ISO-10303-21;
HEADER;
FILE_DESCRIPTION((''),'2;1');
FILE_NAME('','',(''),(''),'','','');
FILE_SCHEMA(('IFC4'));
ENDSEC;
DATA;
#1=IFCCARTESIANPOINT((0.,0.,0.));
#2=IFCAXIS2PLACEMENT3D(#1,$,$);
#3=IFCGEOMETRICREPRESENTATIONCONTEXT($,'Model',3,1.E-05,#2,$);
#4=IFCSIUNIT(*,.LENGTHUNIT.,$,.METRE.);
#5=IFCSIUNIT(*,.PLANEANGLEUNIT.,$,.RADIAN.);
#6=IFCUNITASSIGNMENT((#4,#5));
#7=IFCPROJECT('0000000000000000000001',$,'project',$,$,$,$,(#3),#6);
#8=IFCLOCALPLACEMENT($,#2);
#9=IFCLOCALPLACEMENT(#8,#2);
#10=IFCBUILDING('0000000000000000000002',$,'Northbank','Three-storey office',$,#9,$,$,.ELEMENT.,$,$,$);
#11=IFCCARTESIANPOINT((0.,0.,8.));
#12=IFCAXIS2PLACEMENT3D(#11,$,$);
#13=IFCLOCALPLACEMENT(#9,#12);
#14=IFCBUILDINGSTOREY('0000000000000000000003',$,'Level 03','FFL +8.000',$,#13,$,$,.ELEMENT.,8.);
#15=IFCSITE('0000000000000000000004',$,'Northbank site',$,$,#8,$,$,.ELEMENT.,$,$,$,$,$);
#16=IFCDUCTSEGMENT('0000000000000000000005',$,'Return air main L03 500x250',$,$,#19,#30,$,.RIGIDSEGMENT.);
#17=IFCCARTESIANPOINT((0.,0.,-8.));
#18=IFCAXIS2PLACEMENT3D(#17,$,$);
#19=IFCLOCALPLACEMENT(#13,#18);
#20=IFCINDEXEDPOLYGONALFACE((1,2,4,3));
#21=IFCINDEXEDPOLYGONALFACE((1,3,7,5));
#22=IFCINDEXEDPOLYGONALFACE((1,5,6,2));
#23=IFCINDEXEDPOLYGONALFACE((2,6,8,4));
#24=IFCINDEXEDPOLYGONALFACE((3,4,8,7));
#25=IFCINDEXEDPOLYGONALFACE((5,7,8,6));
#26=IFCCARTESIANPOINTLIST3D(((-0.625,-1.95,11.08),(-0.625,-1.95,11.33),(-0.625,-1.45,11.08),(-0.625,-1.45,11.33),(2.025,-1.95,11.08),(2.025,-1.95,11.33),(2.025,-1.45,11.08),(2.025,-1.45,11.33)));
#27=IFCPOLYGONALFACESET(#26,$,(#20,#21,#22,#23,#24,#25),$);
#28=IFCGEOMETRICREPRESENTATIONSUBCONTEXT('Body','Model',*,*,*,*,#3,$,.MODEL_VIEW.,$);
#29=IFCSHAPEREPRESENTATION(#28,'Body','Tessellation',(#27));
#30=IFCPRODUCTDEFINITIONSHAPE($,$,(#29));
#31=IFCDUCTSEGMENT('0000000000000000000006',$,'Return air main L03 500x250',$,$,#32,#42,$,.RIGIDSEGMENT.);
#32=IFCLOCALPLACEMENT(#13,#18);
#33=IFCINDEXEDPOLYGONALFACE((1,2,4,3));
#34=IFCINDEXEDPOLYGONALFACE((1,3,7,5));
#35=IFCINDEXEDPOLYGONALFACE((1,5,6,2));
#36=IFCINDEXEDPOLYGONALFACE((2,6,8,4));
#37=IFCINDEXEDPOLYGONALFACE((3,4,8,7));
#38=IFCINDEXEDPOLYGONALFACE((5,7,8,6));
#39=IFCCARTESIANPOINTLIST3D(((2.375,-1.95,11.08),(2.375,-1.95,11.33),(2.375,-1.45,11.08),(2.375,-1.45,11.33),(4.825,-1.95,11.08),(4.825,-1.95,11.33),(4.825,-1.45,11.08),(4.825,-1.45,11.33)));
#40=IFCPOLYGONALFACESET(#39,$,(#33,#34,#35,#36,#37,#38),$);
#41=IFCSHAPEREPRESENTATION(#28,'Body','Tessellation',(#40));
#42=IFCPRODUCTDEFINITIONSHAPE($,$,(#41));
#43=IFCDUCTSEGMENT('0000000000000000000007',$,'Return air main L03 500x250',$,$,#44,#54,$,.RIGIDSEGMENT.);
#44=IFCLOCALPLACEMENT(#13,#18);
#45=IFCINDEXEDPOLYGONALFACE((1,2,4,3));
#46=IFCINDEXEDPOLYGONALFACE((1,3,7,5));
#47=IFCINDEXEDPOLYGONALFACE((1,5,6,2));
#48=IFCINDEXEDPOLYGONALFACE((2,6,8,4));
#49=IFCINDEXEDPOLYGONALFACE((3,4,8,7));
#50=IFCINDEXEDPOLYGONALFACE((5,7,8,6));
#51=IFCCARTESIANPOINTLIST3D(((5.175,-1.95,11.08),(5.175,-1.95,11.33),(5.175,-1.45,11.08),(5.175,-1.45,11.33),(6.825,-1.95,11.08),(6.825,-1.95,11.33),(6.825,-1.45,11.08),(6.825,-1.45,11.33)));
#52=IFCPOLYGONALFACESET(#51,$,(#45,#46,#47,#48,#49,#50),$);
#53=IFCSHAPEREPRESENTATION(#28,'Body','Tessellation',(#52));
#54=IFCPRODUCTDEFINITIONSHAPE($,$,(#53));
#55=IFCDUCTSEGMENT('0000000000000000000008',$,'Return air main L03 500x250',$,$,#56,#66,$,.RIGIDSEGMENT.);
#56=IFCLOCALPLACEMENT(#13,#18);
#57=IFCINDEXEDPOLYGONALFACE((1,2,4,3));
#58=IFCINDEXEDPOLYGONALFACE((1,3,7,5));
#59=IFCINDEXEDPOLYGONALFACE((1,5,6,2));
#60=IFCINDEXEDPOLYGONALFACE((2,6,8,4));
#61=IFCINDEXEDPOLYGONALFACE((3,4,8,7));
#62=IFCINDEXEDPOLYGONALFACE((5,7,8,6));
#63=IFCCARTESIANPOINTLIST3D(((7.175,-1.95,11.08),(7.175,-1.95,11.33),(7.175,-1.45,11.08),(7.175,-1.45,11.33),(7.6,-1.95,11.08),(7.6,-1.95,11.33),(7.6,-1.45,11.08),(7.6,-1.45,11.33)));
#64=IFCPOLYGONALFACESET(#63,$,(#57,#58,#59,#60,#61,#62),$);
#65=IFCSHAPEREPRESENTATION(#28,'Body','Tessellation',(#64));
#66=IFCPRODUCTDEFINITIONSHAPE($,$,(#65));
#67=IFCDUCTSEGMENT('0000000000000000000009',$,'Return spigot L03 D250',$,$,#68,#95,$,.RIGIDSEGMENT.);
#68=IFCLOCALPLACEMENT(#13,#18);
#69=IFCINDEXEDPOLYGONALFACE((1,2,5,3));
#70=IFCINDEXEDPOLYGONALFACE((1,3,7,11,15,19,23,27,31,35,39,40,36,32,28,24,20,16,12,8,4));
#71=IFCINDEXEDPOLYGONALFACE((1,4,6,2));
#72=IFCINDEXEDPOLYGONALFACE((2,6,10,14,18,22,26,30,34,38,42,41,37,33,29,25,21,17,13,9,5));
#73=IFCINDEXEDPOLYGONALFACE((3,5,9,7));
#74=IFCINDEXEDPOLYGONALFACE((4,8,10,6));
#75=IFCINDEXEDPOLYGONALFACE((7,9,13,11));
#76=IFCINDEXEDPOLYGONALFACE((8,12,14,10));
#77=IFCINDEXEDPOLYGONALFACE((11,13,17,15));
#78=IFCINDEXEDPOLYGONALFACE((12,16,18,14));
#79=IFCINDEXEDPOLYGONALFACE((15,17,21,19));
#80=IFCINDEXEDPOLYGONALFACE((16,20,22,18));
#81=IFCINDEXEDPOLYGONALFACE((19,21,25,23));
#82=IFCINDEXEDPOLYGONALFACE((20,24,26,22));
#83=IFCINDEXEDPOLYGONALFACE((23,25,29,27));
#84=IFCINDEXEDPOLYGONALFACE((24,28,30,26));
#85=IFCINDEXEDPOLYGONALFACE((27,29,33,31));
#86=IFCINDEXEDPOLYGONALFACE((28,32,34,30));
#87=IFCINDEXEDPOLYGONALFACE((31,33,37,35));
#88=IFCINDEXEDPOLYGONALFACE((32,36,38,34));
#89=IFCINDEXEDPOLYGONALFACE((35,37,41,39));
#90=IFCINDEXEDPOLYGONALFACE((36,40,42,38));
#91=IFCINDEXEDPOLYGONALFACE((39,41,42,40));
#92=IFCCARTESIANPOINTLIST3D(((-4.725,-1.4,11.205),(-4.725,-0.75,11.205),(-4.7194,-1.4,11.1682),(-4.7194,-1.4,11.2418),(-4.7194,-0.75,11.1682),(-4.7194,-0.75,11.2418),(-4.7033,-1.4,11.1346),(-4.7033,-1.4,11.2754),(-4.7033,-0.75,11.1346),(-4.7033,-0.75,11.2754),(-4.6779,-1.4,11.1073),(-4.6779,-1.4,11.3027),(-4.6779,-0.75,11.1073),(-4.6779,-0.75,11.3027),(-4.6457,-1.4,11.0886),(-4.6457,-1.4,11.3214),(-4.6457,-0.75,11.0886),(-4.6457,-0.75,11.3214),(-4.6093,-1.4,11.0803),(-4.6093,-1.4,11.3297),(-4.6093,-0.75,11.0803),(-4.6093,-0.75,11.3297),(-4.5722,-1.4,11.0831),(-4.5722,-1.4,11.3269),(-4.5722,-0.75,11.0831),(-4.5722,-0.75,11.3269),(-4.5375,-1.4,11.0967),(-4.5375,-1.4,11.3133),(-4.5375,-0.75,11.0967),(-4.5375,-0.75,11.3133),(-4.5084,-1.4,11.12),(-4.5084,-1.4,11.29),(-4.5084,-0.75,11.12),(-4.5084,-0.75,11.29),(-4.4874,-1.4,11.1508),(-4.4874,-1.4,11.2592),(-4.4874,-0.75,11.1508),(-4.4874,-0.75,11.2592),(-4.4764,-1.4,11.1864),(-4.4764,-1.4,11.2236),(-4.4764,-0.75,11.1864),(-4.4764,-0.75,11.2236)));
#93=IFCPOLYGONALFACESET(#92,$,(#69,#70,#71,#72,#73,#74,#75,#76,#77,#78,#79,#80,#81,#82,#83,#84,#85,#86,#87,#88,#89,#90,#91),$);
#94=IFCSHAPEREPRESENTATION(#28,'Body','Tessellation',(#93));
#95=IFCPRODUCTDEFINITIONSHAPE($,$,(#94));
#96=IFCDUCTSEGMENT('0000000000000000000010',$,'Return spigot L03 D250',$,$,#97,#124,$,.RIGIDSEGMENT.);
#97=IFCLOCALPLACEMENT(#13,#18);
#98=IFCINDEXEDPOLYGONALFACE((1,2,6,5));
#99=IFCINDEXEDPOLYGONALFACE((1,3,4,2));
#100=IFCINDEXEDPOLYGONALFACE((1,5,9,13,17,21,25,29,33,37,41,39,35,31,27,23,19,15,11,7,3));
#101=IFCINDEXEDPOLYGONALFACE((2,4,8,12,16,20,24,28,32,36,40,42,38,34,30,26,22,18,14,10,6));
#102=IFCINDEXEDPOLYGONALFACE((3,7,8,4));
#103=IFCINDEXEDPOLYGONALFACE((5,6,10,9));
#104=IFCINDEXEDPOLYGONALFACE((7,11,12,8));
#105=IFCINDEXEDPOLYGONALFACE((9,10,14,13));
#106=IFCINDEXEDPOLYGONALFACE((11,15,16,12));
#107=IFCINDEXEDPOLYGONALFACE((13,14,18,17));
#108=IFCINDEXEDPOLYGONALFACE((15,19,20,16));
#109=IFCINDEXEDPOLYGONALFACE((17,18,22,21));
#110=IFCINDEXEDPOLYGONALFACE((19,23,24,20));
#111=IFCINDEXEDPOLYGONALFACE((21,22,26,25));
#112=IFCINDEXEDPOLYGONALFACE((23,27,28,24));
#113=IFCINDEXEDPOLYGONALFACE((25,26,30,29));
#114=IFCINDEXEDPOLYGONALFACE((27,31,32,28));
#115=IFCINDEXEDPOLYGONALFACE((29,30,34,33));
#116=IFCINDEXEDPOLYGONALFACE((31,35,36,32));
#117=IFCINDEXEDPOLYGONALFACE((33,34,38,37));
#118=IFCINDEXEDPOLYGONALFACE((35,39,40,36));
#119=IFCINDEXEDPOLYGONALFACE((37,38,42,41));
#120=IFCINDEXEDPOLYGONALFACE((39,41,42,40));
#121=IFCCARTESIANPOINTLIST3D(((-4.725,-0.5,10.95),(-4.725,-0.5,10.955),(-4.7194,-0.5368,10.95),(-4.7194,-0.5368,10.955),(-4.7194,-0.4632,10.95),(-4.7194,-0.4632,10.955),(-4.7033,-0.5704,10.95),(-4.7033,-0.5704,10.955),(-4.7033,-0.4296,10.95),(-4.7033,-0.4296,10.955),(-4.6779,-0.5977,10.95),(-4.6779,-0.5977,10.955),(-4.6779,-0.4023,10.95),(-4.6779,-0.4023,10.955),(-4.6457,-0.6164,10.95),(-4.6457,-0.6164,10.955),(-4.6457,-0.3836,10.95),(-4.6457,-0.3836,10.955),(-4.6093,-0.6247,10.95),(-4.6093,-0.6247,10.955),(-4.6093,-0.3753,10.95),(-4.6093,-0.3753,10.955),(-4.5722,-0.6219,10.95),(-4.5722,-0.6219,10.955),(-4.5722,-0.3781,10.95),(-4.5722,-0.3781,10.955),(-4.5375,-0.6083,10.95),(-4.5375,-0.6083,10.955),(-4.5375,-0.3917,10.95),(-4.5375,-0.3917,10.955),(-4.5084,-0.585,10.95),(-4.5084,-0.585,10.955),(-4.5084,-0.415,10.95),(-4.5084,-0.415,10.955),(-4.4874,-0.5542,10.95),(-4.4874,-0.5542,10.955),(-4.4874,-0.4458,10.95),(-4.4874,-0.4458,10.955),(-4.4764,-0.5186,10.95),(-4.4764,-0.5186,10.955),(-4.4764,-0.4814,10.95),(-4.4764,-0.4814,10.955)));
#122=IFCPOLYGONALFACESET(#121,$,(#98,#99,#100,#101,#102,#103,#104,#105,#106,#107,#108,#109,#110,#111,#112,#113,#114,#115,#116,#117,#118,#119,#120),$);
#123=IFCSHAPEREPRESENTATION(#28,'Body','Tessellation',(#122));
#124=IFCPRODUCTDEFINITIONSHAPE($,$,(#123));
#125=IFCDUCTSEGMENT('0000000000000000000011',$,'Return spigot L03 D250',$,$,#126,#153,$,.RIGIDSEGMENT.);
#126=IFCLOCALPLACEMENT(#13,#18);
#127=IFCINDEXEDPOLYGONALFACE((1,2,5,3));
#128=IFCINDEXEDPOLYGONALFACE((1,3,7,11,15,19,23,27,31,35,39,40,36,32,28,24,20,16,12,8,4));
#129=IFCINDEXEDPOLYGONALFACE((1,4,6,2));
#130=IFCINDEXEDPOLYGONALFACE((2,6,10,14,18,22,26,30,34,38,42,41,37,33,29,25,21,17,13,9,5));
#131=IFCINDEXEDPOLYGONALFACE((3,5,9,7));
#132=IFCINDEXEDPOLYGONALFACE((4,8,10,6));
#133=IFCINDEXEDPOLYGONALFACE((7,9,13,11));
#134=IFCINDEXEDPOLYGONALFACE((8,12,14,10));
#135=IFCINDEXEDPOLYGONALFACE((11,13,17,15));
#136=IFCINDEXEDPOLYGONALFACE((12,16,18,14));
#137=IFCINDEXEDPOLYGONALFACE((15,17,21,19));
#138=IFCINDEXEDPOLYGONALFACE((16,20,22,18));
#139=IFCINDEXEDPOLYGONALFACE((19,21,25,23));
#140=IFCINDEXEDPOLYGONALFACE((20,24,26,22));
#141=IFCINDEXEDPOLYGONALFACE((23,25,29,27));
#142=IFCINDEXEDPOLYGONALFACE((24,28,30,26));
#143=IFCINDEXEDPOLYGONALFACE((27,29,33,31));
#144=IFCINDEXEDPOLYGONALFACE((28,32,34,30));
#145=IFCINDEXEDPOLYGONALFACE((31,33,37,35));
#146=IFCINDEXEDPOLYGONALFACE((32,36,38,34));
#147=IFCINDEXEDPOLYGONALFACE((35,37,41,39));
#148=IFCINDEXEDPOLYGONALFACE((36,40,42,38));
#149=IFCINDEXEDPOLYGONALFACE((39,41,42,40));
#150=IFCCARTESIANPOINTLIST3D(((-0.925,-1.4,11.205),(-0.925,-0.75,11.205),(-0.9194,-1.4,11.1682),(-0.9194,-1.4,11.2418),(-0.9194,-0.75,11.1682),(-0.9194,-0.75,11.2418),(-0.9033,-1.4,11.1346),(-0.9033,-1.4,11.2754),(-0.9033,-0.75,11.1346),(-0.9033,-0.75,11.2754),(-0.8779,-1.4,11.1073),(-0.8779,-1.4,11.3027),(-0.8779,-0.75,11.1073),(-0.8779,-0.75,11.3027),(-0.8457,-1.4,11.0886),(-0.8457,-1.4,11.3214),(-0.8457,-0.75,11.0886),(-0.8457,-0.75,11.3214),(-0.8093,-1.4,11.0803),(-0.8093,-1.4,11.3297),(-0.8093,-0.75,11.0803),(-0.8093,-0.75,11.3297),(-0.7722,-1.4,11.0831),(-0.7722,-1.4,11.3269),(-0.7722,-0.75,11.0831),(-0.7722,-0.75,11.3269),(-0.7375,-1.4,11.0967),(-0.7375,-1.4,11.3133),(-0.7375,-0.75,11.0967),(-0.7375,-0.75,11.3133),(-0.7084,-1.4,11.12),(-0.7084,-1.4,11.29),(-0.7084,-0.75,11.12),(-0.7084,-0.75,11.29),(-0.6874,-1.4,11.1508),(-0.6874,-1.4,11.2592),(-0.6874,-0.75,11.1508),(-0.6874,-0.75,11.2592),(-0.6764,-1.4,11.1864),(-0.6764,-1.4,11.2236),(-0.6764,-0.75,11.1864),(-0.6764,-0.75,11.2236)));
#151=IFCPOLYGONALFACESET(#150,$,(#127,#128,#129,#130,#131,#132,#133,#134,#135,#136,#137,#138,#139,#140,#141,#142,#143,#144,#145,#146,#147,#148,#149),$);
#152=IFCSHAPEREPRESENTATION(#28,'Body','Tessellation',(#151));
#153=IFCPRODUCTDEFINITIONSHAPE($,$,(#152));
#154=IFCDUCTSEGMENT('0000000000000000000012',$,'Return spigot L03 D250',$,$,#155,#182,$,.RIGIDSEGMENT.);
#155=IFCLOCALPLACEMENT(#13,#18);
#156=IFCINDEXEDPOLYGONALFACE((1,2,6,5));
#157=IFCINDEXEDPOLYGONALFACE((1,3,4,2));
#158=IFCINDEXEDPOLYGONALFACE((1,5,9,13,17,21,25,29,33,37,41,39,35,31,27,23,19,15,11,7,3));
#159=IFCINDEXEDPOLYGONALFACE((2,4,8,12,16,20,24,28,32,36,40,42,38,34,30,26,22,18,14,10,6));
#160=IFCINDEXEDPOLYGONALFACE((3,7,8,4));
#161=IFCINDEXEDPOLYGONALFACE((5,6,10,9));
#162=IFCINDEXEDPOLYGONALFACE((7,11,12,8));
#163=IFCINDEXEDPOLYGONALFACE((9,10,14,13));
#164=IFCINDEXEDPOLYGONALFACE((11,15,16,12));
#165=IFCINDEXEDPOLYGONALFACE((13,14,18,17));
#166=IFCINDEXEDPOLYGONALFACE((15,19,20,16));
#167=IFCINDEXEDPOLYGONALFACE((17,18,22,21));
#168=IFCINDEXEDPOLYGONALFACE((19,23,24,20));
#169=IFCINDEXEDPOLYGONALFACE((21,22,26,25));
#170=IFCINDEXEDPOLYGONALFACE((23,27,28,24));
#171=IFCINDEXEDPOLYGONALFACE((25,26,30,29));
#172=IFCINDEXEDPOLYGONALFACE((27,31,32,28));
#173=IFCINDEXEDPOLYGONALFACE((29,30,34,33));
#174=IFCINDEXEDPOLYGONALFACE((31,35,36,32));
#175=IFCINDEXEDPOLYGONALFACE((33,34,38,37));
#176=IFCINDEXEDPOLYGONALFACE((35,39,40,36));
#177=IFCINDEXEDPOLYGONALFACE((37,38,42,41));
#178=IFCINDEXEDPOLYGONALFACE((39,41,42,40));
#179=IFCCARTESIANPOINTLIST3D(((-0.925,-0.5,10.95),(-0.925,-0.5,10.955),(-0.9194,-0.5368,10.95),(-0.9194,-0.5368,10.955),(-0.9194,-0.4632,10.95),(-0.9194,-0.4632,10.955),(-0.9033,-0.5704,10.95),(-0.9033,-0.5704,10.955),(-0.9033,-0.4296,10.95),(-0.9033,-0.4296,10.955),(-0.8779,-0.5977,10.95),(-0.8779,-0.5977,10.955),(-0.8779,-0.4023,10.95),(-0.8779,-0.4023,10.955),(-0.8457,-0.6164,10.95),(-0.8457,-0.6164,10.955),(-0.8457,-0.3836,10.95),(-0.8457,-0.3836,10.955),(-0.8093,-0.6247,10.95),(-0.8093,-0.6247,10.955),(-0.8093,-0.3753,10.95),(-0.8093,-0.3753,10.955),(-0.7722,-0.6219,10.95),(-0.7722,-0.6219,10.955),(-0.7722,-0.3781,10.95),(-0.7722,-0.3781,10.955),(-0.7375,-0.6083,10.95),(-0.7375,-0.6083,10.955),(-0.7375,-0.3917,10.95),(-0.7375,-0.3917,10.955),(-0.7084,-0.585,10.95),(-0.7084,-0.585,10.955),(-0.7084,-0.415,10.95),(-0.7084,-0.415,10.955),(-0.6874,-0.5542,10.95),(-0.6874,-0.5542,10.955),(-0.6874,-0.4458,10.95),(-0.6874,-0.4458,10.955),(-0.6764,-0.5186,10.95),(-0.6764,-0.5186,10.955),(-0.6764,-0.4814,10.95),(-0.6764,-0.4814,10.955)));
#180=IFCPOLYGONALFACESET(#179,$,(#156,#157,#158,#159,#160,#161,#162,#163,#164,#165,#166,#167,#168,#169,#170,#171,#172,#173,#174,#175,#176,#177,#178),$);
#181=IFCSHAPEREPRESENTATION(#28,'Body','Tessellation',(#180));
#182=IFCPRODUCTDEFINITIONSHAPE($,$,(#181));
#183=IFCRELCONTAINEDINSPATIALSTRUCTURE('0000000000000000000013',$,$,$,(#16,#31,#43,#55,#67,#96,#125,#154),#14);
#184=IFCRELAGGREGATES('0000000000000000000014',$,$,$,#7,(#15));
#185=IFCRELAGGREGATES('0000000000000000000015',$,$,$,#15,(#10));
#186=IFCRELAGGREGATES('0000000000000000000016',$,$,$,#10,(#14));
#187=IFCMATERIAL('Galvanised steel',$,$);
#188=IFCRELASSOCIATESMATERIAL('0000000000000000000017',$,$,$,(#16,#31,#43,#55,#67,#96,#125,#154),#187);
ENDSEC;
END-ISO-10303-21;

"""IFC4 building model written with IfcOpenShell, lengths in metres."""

from ifc_helpers import new_model, si_unit, frame, origin, place, context, subcontext, project, spatial, rectangle, circle, extrude, material, element, save


model = new_model("IFC4")

# Units and contexts
model_context = context("Model", 3, precision=1e-05, world=origin())
body_context = subcontext(model_context, "Body", "Model", "MODEL_VIEW")
ifc_project = project(units=[si_unit("LENGTHUNIT", "METRE"), si_unit("PLANEANGLEUNIT", "RADIAN")], contexts=[model_context])

# Site, building, storey
site_placement = place(None, origin())
site = spatial("IfcSite", under=ifc_project, at=site_placement, Name="Northbank site", CompositionType="ELEMENT")
building_placement = place(site_placement, origin())
building = spatial("IfcBuilding", under=site, at=building_placement, Name="Northbank", Description="Three-storey office", CompositionType="ELEMENT")
storey_placement = place(building_placement, frame((0.0, 0.0, 8.0)))
storey = spatial("IfcBuildingStorey", under=building, at=storey_placement, Name="Level 03", Description="FFL +8.000", CompositionType="ELEMENT", Elevation=8.0)

# Shared definitions
ifc_material_1 = material(Name="Galvanised steel")

# Duct segment
duct_segment_1_placement = place(storey_placement, frame((0.0, 0.0, -8.0)))
element("IfcDuctSegment", 1, at=duct_segment_1_placement, inside=storey, material=ifc_material_1, Name="Return air main L03 500x250", PredefinedType="RIGIDSEGMENT", context=body_context, shape_type="SweptSolid", body=[
    extrude(rectangle(XDim=0.5, YDim=0.25), frame((-0.625, -1.7, 11.205), z_axis=(1.0, 0.0, 0.0), x_axis=(0.0, 1.0, 0.0)), (0.0, 0.0, 1.0), 2.65),
])

# Duct segment
duct_segment_2_placement = place(storey_placement, frame((0.0, 0.0, -8.0)))
element("IfcDuctSegment", 2, at=duct_segment_2_placement, inside=storey, material=ifc_material_1, Name="Return air main L03 500x250", PredefinedType="RIGIDSEGMENT", context=body_context, shape_type="SweptSolid", body=[
    extrude(rectangle(XDim=0.5, YDim=0.25), frame((2.375, -1.7, 11.205), z_axis=(1.0, 0.0, 0.0), x_axis=(0.0, 1.0, 0.0)), (0.0, 0.0, 1.0), 2.45),
])

# Duct segments
duct_segment_3_placement = place(storey_placement, frame((0.0, 0.0, -8.0)))
element("IfcDuctSegment", 3, at=duct_segment_3_placement, inside=storey, material=ifc_material_1, Name="Return air main L03 500x250", PredefinedType="RIGIDSEGMENT", context=body_context, shape_type="SweptSolid", body=[
    extrude(rectangle(XDim=0.5, YDim=0.25), frame((5.175, -1.7, 11.205), z_axis=(1.0, 0.0, 0.0), x_axis=(0.0, 1.0, 0.0)), (0.0, 0.0, 1.0), 1.65),
])
duct_segment_4_placement = place(storey_placement, frame((0.0, 0.0, -8.0)))
element("IfcDuctSegment", 4, at=duct_segment_4_placement, inside=storey, material=ifc_material_1, Name="Return air main L03 500x250", PredefinedType="RIGIDSEGMENT", context=body_context, shape_type="SweptSolid", body=[
    extrude(rectangle(XDim=0.5, YDim=0.25), frame((7.175, -1.7, 11.205), z_axis=(1.0, 0.0, 0.0), x_axis=(0.0, 1.0, 0.0)), (0.0, 0.0, 1.0), 0.425),
])

# Duct segments
duct_segment_5_placement = place(storey_placement, frame((0.0, 0.0, -8.0)))
element("IfcDuctSegment", 5, at=duct_segment_5_placement, inside=storey, material=ifc_material_1, Name="Return spigot L03 D250", PredefinedType="RIGIDSEGMENT", context=body_context, shape_type="SweptSolid", body=[
    extrude(circle(Radius=0.125), frame((-4.6, -1.4, 11.205), z_axis=(0.0, 1.0, 0.0), x_axis=(-1.0, 0.0, 0.0)), (0.0, 0.0, 1.0), 0.65),
])
duct_segment_6_placement = place(storey_placement, frame((0.0, 0.0, -8.0)))
element("IfcDuctSegment", 6, at=duct_segment_6_placement, inside=storey, material=ifc_material_1, Name="Return spigot L03 D250", PredefinedType="RIGIDSEGMENT", context=body_context, shape_type="SweptSolid", body=[
    extrude(circle(Radius=0.125), frame((-4.6, -0.5, 10.955), z_axis=(0.0, 0.0, -1.0), x_axis=(-1.0, 0.0, 0.0)), (0.0, 0.0, 1.0), 0.005),
])

# Duct segments
duct_segment_7_placement = place(storey_placement, frame((0.0, 0.0, -8.0)))
element("IfcDuctSegment", 7, at=duct_segment_7_placement, inside=storey, material=ifc_material_1, Name="Return spigot L03 D250", PredefinedType="RIGIDSEGMENT", context=body_context, shape_type="SweptSolid", body=[
    extrude(circle(Radius=0.125), frame((-0.8, -1.4, 11.205), z_axis=(0.0, 1.0, 0.0), x_axis=(-1.0, 0.0, 0.0)), (0.0, 0.0, 1.0), 0.65),
])
duct_segment_8_placement = place(storey_placement, frame((0.0, 0.0, -8.0)))
element("IfcDuctSegment", 8, at=duct_segment_8_placement, inside=storey, material=ifc_material_1, Name="Return spigot L03 D250", PredefinedType="RIGIDSEGMENT", context=body_context, shape_type="SweptSolid", body=[
    extrude(circle(Radius=0.125), frame((-0.8, -0.5, 10.955), z_axis=(0.0, 0.0, -1.0), x_axis=(-1.0, 0.0, 0.0)), (0.0, 0.0, 1.0), 0.005),
])

save(model, "model.ifc")
